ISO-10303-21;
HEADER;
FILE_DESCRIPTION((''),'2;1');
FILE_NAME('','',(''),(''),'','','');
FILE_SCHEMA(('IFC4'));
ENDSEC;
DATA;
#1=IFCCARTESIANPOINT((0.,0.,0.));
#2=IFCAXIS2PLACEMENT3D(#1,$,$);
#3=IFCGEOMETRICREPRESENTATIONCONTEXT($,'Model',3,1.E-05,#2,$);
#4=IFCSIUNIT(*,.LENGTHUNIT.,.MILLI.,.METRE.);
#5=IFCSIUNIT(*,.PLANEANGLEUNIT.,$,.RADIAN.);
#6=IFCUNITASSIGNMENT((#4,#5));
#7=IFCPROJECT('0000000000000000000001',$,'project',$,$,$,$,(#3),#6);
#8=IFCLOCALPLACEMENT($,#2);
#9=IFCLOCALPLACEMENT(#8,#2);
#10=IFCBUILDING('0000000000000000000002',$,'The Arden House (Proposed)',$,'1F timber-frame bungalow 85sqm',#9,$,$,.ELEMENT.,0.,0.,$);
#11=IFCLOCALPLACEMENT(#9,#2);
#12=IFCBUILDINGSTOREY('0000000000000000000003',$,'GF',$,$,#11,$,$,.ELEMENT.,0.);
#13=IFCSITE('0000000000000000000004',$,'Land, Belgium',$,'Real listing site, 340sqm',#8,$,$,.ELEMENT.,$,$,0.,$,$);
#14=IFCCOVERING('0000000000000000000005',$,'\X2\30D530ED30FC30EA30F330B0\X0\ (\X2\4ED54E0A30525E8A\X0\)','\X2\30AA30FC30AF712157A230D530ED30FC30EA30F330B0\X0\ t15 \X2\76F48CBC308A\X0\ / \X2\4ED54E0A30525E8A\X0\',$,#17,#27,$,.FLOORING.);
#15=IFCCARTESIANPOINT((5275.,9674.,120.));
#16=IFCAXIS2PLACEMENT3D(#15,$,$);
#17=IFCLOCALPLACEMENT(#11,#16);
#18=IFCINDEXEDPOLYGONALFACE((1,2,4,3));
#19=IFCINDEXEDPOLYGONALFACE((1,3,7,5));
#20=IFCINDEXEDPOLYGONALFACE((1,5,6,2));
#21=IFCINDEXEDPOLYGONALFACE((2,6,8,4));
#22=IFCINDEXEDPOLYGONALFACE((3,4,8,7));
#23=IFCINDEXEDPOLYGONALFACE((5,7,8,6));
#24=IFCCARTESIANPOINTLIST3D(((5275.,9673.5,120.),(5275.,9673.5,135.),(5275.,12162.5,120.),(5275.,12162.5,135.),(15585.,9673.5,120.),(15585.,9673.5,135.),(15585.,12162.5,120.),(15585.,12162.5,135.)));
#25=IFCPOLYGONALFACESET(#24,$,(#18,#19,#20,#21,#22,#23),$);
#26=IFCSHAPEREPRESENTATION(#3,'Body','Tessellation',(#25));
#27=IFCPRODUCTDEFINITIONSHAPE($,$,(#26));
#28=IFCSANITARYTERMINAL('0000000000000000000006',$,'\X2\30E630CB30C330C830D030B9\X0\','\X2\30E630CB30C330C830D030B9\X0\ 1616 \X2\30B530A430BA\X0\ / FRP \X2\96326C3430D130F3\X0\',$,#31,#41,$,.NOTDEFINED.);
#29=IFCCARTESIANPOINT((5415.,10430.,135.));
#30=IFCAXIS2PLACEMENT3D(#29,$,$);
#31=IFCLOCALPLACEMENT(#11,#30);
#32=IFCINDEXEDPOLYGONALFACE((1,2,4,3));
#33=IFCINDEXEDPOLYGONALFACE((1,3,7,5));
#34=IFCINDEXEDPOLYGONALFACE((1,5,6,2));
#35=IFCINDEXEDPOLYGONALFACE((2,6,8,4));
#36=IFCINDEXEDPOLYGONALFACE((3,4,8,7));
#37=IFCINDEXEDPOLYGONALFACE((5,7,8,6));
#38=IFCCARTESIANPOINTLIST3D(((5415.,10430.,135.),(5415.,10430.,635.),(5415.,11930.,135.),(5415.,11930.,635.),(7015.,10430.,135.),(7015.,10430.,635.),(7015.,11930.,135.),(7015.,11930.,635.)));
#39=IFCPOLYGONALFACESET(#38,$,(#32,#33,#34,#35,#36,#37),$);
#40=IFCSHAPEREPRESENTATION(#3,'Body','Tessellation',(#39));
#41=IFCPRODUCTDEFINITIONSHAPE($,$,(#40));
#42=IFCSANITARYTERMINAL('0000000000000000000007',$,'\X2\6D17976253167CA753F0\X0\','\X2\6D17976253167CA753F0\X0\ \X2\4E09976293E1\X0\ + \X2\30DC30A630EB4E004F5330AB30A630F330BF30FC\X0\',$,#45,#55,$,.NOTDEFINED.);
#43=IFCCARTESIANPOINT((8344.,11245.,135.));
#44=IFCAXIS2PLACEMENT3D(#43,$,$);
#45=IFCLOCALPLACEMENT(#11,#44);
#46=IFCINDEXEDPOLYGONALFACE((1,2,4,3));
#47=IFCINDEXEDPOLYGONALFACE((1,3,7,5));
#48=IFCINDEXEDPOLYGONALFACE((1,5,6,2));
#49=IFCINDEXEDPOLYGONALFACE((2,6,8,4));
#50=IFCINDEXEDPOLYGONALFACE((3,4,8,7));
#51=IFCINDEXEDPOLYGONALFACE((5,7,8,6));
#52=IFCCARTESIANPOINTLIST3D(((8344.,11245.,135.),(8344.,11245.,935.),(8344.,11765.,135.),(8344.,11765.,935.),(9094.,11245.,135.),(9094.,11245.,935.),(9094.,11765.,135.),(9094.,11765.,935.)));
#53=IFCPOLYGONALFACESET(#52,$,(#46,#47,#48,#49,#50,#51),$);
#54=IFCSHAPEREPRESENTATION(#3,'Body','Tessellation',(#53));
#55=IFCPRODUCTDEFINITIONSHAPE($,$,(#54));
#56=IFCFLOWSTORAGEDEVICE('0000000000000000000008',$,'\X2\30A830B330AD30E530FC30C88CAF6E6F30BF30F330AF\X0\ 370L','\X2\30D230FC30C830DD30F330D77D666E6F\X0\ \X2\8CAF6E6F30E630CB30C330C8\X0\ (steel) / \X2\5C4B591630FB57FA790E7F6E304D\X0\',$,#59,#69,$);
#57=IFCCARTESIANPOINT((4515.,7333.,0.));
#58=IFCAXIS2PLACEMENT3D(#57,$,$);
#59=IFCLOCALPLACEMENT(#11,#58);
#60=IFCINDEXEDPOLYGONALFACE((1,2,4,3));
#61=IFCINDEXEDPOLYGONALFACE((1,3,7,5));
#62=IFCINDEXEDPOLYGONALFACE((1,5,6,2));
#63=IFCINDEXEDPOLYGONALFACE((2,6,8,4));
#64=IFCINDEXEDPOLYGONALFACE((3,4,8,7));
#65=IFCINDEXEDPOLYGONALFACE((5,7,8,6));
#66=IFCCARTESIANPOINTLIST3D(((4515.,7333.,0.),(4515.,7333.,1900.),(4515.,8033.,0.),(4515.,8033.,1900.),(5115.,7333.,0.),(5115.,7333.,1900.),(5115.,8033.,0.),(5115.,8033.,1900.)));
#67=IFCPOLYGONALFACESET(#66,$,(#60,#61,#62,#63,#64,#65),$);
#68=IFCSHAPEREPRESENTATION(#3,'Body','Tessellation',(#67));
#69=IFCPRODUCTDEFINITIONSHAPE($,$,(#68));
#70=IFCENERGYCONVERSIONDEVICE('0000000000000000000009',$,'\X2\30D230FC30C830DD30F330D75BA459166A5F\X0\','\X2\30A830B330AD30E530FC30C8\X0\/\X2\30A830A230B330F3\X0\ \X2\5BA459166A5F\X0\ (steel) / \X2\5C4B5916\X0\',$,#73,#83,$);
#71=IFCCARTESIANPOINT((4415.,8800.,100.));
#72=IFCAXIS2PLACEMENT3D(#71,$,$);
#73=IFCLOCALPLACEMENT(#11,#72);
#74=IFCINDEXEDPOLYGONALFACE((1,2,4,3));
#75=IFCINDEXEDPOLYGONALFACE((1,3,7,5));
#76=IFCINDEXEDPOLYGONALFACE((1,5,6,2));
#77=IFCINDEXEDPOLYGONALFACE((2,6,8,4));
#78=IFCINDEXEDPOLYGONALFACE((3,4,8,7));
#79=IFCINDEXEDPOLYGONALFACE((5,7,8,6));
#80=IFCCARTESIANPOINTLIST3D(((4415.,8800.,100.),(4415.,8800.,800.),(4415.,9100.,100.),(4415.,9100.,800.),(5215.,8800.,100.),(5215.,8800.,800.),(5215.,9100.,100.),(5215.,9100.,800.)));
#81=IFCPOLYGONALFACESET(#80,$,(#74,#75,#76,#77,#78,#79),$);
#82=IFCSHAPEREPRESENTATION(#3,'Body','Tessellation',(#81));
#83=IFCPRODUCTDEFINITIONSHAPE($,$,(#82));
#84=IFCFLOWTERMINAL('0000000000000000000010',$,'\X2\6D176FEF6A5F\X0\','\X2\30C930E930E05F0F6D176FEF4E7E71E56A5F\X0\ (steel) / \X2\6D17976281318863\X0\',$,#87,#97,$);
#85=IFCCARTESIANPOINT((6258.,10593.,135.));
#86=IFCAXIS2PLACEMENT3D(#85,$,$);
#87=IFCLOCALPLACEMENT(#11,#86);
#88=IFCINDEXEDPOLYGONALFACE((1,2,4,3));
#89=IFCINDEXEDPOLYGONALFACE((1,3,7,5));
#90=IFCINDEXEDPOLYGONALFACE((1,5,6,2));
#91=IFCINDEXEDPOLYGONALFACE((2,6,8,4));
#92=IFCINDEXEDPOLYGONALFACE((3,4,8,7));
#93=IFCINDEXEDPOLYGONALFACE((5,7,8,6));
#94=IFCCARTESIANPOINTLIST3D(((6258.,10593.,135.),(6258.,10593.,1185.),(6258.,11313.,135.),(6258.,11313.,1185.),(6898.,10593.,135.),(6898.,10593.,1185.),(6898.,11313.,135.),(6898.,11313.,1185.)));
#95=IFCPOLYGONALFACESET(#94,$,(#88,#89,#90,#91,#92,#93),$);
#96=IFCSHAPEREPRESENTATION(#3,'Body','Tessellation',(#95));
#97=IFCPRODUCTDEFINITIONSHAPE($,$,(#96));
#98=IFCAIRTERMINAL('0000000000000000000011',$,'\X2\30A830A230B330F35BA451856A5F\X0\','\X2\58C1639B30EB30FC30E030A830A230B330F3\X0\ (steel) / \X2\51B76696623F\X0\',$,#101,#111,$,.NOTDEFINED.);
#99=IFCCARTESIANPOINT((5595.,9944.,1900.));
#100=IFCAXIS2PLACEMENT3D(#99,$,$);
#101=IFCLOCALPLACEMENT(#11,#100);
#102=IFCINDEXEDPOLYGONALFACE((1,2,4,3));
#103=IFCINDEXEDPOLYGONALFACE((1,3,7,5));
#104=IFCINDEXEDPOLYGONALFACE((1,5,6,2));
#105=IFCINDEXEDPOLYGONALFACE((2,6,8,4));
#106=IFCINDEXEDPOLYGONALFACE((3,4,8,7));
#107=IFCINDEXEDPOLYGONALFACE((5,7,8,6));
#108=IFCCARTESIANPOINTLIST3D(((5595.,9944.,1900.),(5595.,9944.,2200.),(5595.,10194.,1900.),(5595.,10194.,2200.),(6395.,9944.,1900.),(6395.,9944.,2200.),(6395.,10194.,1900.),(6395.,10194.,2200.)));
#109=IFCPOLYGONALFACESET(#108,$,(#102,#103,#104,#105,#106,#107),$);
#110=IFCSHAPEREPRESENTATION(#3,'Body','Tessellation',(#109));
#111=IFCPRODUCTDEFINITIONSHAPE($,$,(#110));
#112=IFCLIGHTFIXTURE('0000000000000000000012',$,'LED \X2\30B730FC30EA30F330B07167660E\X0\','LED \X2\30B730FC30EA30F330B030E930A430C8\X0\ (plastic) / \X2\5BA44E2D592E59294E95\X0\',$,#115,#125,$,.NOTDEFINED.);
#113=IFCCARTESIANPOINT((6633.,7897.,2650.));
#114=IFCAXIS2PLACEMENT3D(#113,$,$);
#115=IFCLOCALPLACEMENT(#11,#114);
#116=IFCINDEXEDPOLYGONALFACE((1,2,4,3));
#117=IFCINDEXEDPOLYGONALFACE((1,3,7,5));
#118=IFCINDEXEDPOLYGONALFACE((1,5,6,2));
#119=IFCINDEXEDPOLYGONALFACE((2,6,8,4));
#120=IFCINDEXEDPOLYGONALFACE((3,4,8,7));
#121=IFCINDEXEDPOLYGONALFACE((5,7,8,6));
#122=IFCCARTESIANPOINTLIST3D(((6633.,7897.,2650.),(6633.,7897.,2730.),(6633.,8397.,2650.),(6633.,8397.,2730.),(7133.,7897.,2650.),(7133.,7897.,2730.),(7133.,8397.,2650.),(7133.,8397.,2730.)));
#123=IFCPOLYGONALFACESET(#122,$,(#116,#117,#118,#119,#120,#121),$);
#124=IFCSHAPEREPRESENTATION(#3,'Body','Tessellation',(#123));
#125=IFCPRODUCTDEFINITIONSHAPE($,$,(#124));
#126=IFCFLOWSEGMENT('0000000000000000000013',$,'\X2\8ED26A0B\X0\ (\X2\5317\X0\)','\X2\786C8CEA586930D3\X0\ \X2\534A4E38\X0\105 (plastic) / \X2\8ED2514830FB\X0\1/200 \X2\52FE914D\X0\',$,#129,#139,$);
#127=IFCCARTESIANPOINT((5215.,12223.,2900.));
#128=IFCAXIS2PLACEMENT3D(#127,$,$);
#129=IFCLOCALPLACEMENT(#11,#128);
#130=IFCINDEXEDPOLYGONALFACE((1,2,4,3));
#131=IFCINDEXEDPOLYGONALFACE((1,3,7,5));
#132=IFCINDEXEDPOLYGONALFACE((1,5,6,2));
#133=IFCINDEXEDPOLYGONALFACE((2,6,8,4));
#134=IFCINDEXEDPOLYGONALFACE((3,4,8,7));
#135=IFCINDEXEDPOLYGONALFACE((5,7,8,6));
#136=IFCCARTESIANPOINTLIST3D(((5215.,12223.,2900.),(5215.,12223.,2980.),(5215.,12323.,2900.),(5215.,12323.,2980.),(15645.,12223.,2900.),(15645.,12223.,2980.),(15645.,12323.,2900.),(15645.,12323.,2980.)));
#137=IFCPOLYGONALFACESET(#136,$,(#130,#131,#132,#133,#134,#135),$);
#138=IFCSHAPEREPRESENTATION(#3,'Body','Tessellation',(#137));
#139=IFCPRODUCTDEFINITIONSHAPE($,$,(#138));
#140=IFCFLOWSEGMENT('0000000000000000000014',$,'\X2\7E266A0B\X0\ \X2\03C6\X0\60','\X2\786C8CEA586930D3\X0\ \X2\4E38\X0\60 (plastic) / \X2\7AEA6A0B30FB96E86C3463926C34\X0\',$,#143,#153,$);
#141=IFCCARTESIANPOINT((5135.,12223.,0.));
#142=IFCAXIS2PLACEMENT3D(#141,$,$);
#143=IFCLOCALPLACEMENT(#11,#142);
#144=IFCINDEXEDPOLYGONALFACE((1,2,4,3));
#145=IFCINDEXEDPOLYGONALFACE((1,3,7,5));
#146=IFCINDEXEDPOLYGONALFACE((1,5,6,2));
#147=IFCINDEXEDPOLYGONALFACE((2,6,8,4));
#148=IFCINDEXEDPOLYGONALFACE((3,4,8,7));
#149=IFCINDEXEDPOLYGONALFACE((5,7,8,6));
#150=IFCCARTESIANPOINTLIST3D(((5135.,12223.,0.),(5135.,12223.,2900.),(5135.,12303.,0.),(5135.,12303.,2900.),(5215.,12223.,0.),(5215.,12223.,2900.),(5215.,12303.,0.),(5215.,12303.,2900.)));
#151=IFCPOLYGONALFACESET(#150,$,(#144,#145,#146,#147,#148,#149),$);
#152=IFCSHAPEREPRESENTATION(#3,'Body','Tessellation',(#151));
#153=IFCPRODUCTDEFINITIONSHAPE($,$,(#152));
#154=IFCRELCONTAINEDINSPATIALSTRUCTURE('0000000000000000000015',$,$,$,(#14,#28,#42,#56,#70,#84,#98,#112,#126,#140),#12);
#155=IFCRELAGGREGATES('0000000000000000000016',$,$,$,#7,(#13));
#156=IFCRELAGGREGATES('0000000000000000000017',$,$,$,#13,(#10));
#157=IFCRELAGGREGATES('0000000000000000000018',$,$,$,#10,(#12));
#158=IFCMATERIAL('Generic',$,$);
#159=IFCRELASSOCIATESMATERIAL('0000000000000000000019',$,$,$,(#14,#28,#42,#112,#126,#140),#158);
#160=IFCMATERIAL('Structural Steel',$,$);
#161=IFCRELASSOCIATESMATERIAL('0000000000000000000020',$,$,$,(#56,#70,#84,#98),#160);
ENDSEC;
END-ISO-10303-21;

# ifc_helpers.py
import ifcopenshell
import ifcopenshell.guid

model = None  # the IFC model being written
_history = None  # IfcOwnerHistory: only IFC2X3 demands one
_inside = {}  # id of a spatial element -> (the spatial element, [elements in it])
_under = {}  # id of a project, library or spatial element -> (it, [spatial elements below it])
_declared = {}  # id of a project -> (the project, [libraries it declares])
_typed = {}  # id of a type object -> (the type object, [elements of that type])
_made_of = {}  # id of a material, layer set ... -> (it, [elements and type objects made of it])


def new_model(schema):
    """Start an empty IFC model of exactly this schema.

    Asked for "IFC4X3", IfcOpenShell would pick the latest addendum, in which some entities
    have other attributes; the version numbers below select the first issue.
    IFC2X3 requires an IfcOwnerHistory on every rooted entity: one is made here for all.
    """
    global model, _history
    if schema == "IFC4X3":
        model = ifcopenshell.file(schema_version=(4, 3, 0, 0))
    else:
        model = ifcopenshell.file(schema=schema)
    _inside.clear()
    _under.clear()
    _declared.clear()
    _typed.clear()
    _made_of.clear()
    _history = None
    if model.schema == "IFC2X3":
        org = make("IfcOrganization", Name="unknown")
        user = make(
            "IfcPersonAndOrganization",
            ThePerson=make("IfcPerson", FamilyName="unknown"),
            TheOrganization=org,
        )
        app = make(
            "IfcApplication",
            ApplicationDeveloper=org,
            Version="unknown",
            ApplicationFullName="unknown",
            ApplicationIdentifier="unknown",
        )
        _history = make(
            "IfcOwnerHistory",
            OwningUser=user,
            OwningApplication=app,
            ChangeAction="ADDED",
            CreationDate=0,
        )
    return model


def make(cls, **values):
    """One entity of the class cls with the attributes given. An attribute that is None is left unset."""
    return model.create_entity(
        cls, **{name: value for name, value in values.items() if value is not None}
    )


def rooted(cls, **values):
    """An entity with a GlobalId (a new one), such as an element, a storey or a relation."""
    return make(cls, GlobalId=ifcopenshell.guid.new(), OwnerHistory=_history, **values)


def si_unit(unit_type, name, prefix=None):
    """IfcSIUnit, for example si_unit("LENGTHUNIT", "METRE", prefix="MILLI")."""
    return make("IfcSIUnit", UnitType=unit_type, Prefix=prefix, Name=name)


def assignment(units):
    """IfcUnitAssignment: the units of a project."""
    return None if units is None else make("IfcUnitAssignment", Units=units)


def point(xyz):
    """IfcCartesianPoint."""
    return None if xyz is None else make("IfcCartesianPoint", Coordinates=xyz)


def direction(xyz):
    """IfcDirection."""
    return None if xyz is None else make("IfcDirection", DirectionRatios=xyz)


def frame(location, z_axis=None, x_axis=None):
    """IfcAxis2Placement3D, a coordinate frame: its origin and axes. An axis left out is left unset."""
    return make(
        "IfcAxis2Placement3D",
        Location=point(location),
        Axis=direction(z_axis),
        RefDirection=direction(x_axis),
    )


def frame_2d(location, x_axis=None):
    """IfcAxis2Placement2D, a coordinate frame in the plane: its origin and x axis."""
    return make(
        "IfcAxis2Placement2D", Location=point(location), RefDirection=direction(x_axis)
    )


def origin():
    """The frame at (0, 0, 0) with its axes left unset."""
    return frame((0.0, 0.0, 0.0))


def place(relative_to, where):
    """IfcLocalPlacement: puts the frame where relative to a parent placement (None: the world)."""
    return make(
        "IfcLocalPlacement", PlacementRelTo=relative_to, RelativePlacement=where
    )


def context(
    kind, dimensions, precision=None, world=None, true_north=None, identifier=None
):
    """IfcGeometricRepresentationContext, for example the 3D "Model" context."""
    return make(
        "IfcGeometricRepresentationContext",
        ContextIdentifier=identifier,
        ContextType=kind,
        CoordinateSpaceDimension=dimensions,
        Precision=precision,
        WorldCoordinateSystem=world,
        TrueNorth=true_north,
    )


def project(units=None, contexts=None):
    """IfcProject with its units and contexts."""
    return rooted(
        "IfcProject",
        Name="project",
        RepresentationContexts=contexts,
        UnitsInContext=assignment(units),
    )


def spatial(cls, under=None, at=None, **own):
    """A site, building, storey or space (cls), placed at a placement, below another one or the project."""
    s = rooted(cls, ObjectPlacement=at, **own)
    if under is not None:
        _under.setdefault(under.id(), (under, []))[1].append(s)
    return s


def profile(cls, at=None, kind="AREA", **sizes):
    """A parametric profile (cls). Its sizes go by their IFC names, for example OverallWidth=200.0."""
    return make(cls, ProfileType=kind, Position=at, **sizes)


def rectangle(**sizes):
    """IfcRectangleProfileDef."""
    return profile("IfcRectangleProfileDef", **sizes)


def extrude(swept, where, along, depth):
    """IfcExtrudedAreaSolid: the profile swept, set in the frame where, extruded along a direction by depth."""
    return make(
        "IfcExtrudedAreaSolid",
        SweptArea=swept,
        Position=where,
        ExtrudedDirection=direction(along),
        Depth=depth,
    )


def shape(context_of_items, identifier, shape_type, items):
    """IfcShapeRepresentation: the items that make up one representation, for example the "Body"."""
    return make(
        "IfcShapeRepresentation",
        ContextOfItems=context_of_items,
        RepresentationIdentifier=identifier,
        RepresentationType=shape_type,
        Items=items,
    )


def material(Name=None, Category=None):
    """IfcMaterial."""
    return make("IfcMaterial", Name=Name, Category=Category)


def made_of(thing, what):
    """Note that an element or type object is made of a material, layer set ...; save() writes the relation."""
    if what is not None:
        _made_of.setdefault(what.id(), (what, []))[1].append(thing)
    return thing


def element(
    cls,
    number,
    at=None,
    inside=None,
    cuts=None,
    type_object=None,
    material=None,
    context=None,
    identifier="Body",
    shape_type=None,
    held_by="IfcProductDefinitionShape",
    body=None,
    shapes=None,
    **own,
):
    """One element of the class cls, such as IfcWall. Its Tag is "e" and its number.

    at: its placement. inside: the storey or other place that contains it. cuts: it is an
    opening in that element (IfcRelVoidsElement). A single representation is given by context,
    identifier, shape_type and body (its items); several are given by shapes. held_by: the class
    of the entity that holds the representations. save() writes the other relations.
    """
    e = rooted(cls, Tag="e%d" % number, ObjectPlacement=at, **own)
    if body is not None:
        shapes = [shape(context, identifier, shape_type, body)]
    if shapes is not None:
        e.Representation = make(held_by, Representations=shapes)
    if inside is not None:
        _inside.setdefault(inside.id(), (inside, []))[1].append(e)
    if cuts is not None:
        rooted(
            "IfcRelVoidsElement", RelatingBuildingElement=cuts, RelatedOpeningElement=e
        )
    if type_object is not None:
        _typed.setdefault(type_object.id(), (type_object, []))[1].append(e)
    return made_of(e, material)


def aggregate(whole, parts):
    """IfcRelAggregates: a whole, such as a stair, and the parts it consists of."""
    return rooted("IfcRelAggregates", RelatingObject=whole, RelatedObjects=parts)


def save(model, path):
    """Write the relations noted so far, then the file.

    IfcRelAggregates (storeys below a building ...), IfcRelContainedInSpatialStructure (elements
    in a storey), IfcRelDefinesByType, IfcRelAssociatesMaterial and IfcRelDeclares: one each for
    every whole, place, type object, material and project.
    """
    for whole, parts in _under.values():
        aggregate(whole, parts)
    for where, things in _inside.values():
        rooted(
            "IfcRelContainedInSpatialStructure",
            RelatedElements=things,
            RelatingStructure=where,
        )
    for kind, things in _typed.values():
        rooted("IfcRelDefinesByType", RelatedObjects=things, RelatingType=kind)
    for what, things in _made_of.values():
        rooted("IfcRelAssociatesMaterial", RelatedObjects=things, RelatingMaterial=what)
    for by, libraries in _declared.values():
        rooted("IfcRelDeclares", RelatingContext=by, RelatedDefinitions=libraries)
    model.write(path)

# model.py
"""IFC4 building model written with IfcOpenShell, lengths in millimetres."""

from ifc_helpers import new_model, si_unit, frame, frame_2d, origin, place, context, project, spatial, rectangle, extrude, material, element, save


model = new_model("IFC4")

# Units and contexts
model_context = context("Model", 3, precision=1e-05, world=origin())
ifc_project = project(units=[si_unit("LENGTHUNIT", "METRE", prefix="MILLI"), si_unit("PLANEANGLEUNIT", "RADIAN")], contexts=[model_context])

# Site, building, storey
site_placement = place(None, origin())
site = spatial("IfcSite", under=ifc_project, at=site_placement, Name="Land, Belgium", ObjectType="Real listing site, 340sqm", CompositionType="ELEMENT", RefElevation=0.0)
building_placement = place(site_placement, origin())
building = spatial("IfcBuilding", under=site, at=building_placement, Name="The Arden House (Proposed)", ObjectType="1F timber-frame bungalow 85sqm", CompositionType="ELEMENT", ElevationOfRefHeight=0.0, ElevationOfTerrain=0.0)
storey_placement = place(building_placement, origin())
storey = spatial("IfcBuildingStorey", under=building, at=storey_placement, Name="GF", CompositionType="ELEMENT", Elevation=0.0)

# Shared definitions
ifc_material_1 = material(Name="Structural Steel")

# Covering
ifc_material_2 = material(Name="Generic")
covering_1_placement = place(storey_placement, frame((5275.0, 9674.0, 120.0)))
element("IfcCovering", 1, at=covering_1_placement, inside=storey, material=ifc_material_2, Name="フローリング (仕上げ床)", Description="オーク無垢フローリング t15 直貼り / 仕上げ床", PredefinedType="FLOORING", context=model_context, shape_type="SweptSolid", body=[
    extrude(rectangle(XDim=10310.0, YDim=2489.0, at=frame_2d((5155.0, 1244.0))), frame((5275.0, 9674.0, 120.0)), (0.0, 0.0, 1.0), 15.0),
])

# Sanitary terminals
sanitary_terminal_1_placement = place(storey_placement, frame((5415.0, 10430.0, 135.0)))
element("IfcSanitaryTerminal", 2, at=sanitary_terminal_1_placement, inside=storey, material=ifc_material_2, Name="ユニットバス", Description="ユニットバス 1616 サイズ / FRP 防水パン", PredefinedType="NOTDEFINED", context=model_context, shape_type="SweptSolid", body=[
    extrude(rectangle(XDim=1600.0, YDim=1500.0, at=frame_2d((800.0, 750.0))), frame((5415.0, 10430.0, 135.0)), (0.0, 0.0, 1.0), 500.0),
])
sanitary_terminal_2_placement = place(storey_placement, frame((8344.0, 11245.0, 135.0)))
element("IfcSanitaryTerminal", 3, at=sanitary_terminal_2_placement, inside=storey, material=ifc_material_2, Name="洗面化粧台", Description="洗面化粧台 三面鏡 + ボウル一体カウンター", PredefinedType="NOTDEFINED", context=model_context, shape_type="SweptSolid", body=[
    extrude(rectangle(XDim=750.0, YDim=520.0, at=frame_2d((375.0, 260.0))), frame((8344.0, 11245.0, 135.0)), (0.0, 0.0, 1.0), 800.0),
])

# Flow storage device
flow_storage_device_placement = place(storey_placement, frame((4515.0, 7333.0, 0.0)))
element("IfcFlowStorageDevice", 4, at=flow_storage_device_placement, inside=storey, material=ifc_material_1, Name="エコキュート貯湯タンク 370L", Description="ヒートポンプ給湯 貯湯ユニット (steel) / 屋外・基礎置き", context=model_context, shape_type="SweptSolid", body=[
    extrude(rectangle(XDim=600.0, YDim=700.0, at=frame_2d((300.0, 350.0))), frame((4515.0, 7333.0, 0.0)), (0.0, 0.0, 1.0), 1900.0),
])

# Energy conversion device
energy_conversion_device_placement = place(storey_placement, frame((4415.0, 8800.0, 100.0)))
element("IfcEnergyConversionDevice", 5, at=energy_conversion_device_placement, inside=storey, material=ifc_material_1, Name="ヒートポンプ室外機", Description="エコキュート/エアコン 室外機 (steel) / 屋外", context=model_context, shape_type="SweptSolid", body=[
    extrude(rectangle(XDim=800.0, YDim=300.0, at=frame_2d((400.0, 150.0))), frame((4415.0, 8800.0, 100.0)), (0.0, 0.0, 1.0), 700.0),
])

# Flow terminal
flow_terminal_placement = place(storey_placement, frame((6258.0, 10593.0, 135.0)))
element("IfcFlowTerminal", 6, at=flow_terminal_placement, inside=storey, material=ifc_material_1, Name="洗濯機", Description="ドラム式洗濯乾燥機 (steel) / 洗面脱衣", context=model_context, shape_type="SweptSolid", body=[
    extrude(rectangle(XDim=640.0, YDim=720.0, at=frame_2d((320.0, 360.0))), frame((6258.0, 10593.0, 135.0)), (0.0, 0.0, 1.0), 1050.0),
])

# Air terminal
air_terminal_placement = place(storey_placement, frame((5595.0, 9944.0, 1900.0)))
element("IfcAirTerminal", 7, at=air_terminal_placement, inside=storey, material=ifc_material_1, Name="エアコン室内機", Description="壁掛ルームエアコン (steel) / 冷暖房", PredefinedType="NOTDEFINED", context=model_context, shape_type="SweptSolid", body=[
    extrude(rectangle(XDim=800.0, YDim=250.0, at=frame_2d((400.0, 125.0))), frame((5595.0, 9944.0, 1900.0)), (0.0, 0.0, 1.0), 300.0),
])

# Light fixture
light_fixture_placement = place(storey_placement, frame((6633.0, 7897.0, 2650.0)))
element("IfcLightFixture", 8, at=light_fixture_placement, inside=storey, material=ifc_material_2, Name="LED シーリング照明", Description="LED シーリングライト (plastic) / 室中央天井", PredefinedType="NOTDEFINED", context=model_context, shape_type="SweptSolid", body=[
    extrude(rectangle(XDim=500.0, YDim=500.0, at=frame_2d((250.0, 250.0))), frame((6633.0, 7897.0, 2650.0)), (0.0, 0.0, 1.0), 80.0),
])

# Flow segments
flow_segment_1_placement = place(storey_placement, frame((5215.0, 12223.0, 2900.0)))
element("IfcFlowSegment", 9, at=flow_segment_1_placement, inside=storey, material=ifc_material_2, Name="軒樋 (北)", Description="硬質塩ビ 半丸105 (plastic) / 軒先・1/200 勾配", context=model_context, shape_type="SweptSolid", body=[
    extrude(rectangle(XDim=10430.0, YDim=100.0, at=frame_2d((5215.0, 50.0))), frame((5215.0, 12223.0, 2900.0)), (0.0, 0.0, 1.0), 80.0),
])
flow_segment_2_placement = place(storey_placement, frame((5135.0, 12223.0, 0.0)))
element("IfcFlowSegment", 10, at=flow_segment_2_placement, inside=storey, material=ifc_material_2, Name="縦樋 φ60", Description="硬質塩ビ 丸60 (plastic) / 竪樋・雨水排水", context=model_context, shape_type="SweptSolid", body=[
    extrude(rectangle(XDim=80.0, YDim=80.0, at=frame_2d((40.0, 40.0))), frame((5135.0, 12223.0, 0.0)), (0.0, 0.0, 1.0), 2900.0),
])

save(model, "model.ifc")
